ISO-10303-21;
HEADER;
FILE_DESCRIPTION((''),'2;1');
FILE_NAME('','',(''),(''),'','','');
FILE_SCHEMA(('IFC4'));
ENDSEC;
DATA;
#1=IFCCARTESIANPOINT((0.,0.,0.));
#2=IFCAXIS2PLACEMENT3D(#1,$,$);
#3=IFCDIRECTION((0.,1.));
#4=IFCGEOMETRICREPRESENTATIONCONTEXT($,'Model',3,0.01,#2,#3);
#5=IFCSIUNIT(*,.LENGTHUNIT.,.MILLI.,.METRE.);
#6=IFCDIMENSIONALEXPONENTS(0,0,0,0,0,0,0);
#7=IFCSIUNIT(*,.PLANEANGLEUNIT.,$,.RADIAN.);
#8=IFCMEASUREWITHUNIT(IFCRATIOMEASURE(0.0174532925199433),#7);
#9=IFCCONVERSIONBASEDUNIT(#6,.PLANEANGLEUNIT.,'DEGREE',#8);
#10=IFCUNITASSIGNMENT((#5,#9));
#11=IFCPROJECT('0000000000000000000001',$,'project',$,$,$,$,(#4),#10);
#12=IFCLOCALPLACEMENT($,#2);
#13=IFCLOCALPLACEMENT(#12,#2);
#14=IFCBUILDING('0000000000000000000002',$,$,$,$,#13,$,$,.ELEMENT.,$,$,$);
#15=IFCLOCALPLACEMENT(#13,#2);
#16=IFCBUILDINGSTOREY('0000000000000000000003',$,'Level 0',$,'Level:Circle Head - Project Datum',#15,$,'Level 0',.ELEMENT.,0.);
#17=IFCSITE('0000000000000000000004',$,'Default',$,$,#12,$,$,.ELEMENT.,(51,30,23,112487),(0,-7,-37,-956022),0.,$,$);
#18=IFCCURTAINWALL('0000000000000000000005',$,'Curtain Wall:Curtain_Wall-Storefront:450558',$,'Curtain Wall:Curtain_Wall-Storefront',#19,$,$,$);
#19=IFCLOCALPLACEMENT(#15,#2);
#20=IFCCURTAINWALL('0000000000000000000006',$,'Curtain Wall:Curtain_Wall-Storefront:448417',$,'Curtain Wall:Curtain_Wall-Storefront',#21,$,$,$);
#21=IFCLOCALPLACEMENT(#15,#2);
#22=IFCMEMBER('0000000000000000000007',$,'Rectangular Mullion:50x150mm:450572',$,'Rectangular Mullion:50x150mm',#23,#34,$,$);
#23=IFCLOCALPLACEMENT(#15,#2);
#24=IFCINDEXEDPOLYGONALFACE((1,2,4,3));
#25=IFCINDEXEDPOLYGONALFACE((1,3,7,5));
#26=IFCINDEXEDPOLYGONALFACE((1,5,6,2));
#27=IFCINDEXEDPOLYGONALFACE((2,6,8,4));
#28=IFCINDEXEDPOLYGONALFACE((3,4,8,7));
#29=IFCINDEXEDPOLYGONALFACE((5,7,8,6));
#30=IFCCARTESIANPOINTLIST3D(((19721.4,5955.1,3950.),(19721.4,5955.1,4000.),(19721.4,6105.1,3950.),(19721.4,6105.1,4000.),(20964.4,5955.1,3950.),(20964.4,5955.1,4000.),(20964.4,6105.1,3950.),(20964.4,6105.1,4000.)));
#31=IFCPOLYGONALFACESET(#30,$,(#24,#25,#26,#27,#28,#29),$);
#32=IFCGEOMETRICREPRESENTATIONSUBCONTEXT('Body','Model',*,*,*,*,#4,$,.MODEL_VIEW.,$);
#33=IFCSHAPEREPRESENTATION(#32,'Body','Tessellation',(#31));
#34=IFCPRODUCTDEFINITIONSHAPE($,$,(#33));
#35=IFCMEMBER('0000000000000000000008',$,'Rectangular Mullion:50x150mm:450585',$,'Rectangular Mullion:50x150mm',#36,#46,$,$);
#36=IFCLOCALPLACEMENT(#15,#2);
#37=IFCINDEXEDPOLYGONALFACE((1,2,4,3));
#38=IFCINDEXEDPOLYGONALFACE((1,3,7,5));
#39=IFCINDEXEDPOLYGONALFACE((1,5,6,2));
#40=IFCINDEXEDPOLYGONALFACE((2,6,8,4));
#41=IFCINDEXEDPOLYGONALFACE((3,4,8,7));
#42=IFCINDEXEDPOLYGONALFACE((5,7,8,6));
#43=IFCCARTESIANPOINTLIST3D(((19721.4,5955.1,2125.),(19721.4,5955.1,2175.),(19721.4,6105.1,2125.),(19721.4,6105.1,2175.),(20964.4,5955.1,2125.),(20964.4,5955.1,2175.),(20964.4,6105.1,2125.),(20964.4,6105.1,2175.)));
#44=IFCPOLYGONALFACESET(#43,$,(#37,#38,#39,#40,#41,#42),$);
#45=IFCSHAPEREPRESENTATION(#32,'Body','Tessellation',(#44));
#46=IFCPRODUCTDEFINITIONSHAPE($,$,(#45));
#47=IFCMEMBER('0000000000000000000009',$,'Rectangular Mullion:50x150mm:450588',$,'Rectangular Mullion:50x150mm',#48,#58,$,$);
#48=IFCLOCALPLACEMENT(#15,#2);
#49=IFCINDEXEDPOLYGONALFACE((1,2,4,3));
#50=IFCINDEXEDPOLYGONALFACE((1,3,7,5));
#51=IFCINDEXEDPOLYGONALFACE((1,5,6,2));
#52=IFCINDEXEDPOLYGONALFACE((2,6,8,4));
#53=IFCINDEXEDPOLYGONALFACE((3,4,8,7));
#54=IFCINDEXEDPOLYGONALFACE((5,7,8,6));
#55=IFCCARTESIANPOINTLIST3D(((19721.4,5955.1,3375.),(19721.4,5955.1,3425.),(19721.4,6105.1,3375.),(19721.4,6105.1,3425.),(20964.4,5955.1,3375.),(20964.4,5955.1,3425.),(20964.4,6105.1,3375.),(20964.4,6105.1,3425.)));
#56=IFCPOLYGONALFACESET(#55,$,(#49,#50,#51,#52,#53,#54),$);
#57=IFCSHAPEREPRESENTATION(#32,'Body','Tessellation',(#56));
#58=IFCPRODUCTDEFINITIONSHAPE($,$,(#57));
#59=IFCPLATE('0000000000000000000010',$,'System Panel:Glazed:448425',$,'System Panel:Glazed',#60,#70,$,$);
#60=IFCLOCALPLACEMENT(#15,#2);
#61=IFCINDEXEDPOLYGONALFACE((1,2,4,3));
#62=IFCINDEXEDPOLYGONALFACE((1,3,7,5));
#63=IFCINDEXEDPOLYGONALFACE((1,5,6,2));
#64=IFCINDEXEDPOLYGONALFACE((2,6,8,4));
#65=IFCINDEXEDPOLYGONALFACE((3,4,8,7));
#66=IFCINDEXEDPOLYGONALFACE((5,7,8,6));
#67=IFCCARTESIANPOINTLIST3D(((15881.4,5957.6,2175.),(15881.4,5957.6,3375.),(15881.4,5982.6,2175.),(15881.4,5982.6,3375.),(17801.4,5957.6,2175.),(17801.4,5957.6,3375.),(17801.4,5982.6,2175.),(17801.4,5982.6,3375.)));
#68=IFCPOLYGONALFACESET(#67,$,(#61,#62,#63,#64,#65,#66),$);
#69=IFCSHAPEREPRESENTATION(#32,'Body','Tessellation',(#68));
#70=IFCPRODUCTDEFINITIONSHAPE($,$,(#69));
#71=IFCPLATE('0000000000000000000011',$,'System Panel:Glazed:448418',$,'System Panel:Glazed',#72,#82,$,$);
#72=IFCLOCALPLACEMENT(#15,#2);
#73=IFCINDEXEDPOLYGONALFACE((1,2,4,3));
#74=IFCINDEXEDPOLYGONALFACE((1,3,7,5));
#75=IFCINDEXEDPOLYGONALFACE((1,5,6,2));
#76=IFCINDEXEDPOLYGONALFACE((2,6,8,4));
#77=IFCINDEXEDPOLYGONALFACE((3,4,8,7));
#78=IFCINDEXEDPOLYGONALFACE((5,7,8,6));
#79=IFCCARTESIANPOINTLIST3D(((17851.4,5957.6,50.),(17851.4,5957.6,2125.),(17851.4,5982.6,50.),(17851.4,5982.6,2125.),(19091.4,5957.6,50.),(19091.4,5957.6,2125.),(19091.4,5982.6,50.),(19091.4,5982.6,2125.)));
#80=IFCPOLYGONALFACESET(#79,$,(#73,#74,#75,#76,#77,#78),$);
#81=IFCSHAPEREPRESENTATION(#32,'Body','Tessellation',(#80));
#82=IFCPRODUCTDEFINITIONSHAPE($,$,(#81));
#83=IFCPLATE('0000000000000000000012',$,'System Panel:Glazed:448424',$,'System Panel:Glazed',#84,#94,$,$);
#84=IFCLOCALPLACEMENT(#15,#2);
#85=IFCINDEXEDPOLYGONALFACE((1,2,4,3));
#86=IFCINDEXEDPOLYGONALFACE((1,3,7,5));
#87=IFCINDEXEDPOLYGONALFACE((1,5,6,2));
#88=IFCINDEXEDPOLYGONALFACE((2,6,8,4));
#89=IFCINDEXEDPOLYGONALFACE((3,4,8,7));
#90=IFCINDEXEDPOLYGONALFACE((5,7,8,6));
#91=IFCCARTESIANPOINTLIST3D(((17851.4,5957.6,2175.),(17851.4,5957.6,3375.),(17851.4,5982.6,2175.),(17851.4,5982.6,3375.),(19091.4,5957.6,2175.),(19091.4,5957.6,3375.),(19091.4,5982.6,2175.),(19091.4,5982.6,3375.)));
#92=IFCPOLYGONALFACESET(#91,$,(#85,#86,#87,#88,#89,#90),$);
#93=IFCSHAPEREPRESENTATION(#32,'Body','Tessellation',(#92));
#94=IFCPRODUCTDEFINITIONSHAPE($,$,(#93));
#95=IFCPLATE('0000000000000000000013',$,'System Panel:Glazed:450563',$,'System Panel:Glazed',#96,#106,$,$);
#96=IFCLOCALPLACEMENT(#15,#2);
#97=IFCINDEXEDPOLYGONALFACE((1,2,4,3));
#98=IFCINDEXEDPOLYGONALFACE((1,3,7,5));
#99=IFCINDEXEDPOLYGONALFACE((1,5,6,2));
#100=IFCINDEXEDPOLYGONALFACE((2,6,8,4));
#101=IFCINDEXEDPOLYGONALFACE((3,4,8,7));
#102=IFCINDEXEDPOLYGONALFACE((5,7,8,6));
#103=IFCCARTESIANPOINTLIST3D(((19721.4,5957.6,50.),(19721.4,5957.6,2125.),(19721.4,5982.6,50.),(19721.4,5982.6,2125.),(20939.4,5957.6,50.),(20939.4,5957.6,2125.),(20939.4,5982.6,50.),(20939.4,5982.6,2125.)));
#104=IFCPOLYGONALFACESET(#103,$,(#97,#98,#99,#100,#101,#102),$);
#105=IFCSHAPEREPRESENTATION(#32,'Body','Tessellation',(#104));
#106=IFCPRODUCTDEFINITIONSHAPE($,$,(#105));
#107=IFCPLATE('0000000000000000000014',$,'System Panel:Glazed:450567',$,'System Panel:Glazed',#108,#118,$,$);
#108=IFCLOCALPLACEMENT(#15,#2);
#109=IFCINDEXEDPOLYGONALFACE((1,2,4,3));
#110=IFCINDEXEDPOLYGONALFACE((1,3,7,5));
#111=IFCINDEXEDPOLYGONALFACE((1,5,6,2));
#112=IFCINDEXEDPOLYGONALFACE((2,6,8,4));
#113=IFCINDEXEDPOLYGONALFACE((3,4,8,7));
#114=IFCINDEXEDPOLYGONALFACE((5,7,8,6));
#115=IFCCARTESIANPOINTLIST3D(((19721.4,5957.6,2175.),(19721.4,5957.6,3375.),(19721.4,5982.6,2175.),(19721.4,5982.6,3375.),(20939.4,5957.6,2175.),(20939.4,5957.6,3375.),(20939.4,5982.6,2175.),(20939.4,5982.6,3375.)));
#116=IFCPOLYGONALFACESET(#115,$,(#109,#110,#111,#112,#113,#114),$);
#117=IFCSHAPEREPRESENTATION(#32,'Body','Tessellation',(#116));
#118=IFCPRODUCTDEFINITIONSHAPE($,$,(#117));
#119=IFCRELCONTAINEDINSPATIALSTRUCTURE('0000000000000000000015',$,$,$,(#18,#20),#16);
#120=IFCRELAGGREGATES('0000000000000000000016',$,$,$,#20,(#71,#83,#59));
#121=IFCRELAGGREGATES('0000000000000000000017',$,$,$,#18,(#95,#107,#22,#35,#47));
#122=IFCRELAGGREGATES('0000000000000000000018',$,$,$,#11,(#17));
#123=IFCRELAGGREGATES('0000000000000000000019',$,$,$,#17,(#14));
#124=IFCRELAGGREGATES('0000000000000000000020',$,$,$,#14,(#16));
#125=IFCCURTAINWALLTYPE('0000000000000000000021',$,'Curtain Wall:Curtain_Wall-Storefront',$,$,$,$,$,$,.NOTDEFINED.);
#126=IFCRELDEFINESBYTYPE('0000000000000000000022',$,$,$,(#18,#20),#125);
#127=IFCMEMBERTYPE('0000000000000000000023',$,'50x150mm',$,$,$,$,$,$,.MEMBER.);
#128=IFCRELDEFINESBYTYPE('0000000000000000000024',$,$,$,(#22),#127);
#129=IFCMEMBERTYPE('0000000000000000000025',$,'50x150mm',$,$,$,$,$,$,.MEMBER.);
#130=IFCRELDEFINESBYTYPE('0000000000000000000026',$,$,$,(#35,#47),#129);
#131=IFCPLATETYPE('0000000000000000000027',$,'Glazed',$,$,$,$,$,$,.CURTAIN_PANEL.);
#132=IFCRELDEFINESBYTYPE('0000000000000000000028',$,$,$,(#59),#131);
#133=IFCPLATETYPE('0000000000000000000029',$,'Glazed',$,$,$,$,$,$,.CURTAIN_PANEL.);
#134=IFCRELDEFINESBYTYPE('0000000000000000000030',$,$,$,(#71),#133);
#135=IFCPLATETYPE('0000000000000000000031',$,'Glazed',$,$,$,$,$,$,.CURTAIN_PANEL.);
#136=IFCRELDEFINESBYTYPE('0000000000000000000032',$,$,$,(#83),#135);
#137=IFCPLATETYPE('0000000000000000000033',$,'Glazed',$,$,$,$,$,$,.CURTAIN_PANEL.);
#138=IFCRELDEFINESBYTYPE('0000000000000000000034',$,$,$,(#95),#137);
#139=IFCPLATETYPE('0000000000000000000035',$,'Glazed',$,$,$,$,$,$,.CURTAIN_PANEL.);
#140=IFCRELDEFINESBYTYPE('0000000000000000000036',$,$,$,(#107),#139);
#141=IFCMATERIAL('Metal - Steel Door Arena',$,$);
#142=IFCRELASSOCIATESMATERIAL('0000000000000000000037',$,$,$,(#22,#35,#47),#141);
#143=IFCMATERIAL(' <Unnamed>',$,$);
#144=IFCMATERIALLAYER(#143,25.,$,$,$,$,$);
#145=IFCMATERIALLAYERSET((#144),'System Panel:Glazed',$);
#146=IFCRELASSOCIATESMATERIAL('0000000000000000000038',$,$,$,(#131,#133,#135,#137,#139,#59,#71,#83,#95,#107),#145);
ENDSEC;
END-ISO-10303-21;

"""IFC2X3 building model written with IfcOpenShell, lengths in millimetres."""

from ifc_helpers import new_model, entity, si_unit, converted_unit, direction, frame, origin, origin_2d_with_axis, place, context, subcontext, project, spatial, rectangle, extrude, source, transform, mapped, material, layer, layer_set, layer_usage, type_object, type_shapes, element, aggregate, save


model = new_model("IFC2X3")

# Units and contexts
model_context = context("Model", 3, precision=0.01, world=origin(), true_north=direction((0.0, 1.0)))
body_context = subcontext(model_context, "Body", "Model", "MODEL_VIEW")
ifc_project = project(units=[si_unit("LENGTHUNIT", "METRE", prefix="MILLI"), converted_unit("PLANEANGLEUNIT", "DEGREE", entity("IfcRatioMeasure", 0.0174532925199433), si_unit("PLANEANGLEUNIT", "RADIAN"), dimensions=[0, 0, 0, 0, 0, 0, 0])], contexts=[model_context])

# Site, building, storey
site_placement = place(None, origin())
site = spatial("IfcSite", under=ifc_project, at=site_placement, Name="Default", CompositionType="ELEMENT", RefLatitude=(51, 30, 23, 112487), RefLongitude=(0, -7, -37, -956022), RefElevation=0.0)
building_placement = place(site_placement, origin())
building = spatial("IfcBuilding", under=site, at=building_placement, CompositionType="ELEMENT")
storey_placement = place(building_placement, origin())
storey = spatial("IfcBuildingStorey", under=building, at=storey_placement, Name="Level 0", ObjectType="Level:Circle Head - Project Datum", LongName="Level 0", CompositionType="ELEMENT", Elevation=0.0)

# Curtain walls
curtain_wall_type = type_object("IfcCurtainWallType", Name="Curtain Wall:Curtain_Wall-Storefront", PredefinedType="NOTDEFINED")
curtain_wall_1_placement = place(storey_placement, origin())
curtain_wall_1 = element("IfcCurtainWall", 1, at=curtain_wall_1_placement, inside=storey, type_object=curtain_wall_type, Name="Curtain Wall:Curtain_Wall-Storefront:450558", ObjectType="Curtain Wall:Curtain_Wall-Storefront")
ifc_material_1 = material(Name="Metal - Steel Door Arena")
curtain_wall_2_placement = place(storey_placement, origin())
curtain_wall_2 = element("IfcCurtainWall", 2, at=curtain_wall_2_placement, inside=storey, type_object=curtain_wall_type, Name="Curtain Wall:Curtain_Wall-Storefront:448417", ObjectType="Curtain Wall:Curtain_Wall-Storefront")

# Members
member_type_1 = type_object("IfcMemberType", Name="50x150mm", PredefinedType="MEMBER")
shared_shape_1 = source(origin(), body_context, "Body", "SweptSolid", [
    extrude(rectangle(XDim=150.0, YDim=50.0, at=origin_2d_with_axis()), frame((-25.0, 0.0, -1243.0), z_axis=(0.0, 0.0, 1.0), x_axis=(0.0, -1.0, 0.0)), (0.0, 0.0, 1.0), 1243.0),
])
type_shapes(member_type_1, [shared_shape_1])
member_1_placement = place(storey_placement, frame((19721.4, 6030.1, 4000.0), z_axis=(-1.0, 0.0, 0.0), x_axis=(0.0, 0.0, 1.0)))
member_1 = element("IfcMember", 3, at=member_1_placement, type_object=member_type_1, material=ifc_material_1, Name="Rectangular Mullion:50x150mm:450572", ObjectType="Rectangular Mullion:50x150mm", context=body_context, shape_type="MappedRepresentation", body=[
    mapped(shared_shape_1, transform((0.0, 0.0, 0.0), scale=1.0)),
])
member_type_2 = type_object("IfcMemberType", Name="50x150mm", PredefinedType="MEMBER")
shared_shape_2 = source(origin(), body_context, "Body", "SweptSolid", [
    extrude(rectangle(XDim=150.0, YDim=50.0, at=origin_2d_with_axis()), frame((0.0, 0.0, -1243.0), z_axis=(0.0, 0.0, 1.0), x_axis=(0.0, -1.0, 0.0)), (0.0, 0.0, 1.0), 1243.0),
])
type_shapes(member_type_2, [shared_shape_2])
member_2_placement = place(storey_placement, frame((19721.4, 6030.1, 2150.0), z_axis=(-1.0, 0.0, 0.0), x_axis=(0.0, 0.0, 1.0)))
member_2 = element("IfcMember", 4, at=member_2_placement, type_object=member_type_2, material=ifc_material_1, Name="Rectangular Mullion:50x150mm:450585", ObjectType="Rectangular Mullion:50x150mm", context=body_context, shape_type="MappedRepresentation", body=[
    mapped(shared_shape_2, transform((0.0, 0.0, 0.0), scale=1.0)),
])
member_3_placement = place(storey_placement, frame((19721.4, 6030.1, 3400.0), z_axis=(-1.0, 0.0, 0.0), x_axis=(0.0, 0.0, 1.0)))
member_3 = element("IfcMember", 5, at=member_3_placement, type_object=member_type_2, material=ifc_material_1, Name="Rectangular Mullion:50x150mm:450588", ObjectType="Rectangular Mullion:50x150mm", context=body_context, shape_type="MappedRepresentation", body=[
    mapped(shared_shape_2, transform((0.0, 0.0, 0.0), scale=1.0)),
])

# Plates
ifc_material_2 = material(Name=" <Unnamed>")
ifc_layer_1 = layer(ifc_material_2, 25.0)
ifc_layer_set_1 = layer_set([ifc_layer_1], Name="System Panel:Glazed")
ifc_layer_usage_1 = layer_usage(ifc_layer_set_1, "AXIS3", "POSITIVE", 0.2)
plate_type_1 = type_object("IfcPlateType", Name="Glazed", PredefinedType="CURTAIN_PANEL", material=ifc_layer_set_1)
shared_shape_3 = source(origin(), body_context, "Body", "SweptSolid", [
    extrude(rectangle(XDim=25.0, YDim=1920.0, at=origin_2d_with_axis()), frame((0.0, 60.0, 0.0), z_axis=(0.0, 0.0, 1.0), x_axis=(0.0, 1.0, 0.0)), (0.0, 0.0, 1.0), 1200.0),
])
type_shapes(plate_type_1, [shared_shape_3])
plate_1_placement = place(curtain_wall_2_placement, frame((16841.4, 6030.1, 2175.0), z_axis=(0.0, 0.0, 1.0), x_axis=(-1.0, 0.0, 0.0)))
plate_1 = element("IfcPlate", 6, at=plate_1_placement, type_object=plate_type_1, material=ifc_layer_usage_1, Name="System Panel:Glazed:448425", ObjectType="System Panel:Glazed", context=body_context, shape_type="MappedRepresentation", body=[
    mapped(shared_shape_3, transform((0.0, 0.0, 0.0), scale=1.0)),
])
ifc_layer_usage_2 = layer_usage(ifc_layer_set_1, "AXIS3", "POSITIVE", 0.2)
plate_type_2 = type_object("IfcPlateType", Name="Glazed", PredefinedType="CURTAIN_PANEL", material=ifc_layer_set_1)
shared_shape_4 = source(origin(), body_context, "Body", "SweptSolid", [
    extrude(rectangle(XDim=25.0, YDim=1240.0, at=origin_2d_with_axis()), frame((0.0, 60.0, 0.0), z_axis=(0.0, 0.0, 1.0), x_axis=(0.0, 1.0, 0.0)), (0.0, 0.0, 1.0), 2075.0),
])
type_shapes(plate_type_2, [shared_shape_4])
plate_2_placement = place(curtain_wall_2_placement, frame((18471.4, 6030.1, 50.0), z_axis=(0.0, 0.0, 1.0), x_axis=(-1.0, 0.0, 0.0)))
plate_2 = element("IfcPlate", 7, at=plate_2_placement, type_object=plate_type_2, material=ifc_layer_usage_2, Name="System Panel:Glazed:448418", ObjectType="System Panel:Glazed", context=body_context, shape_type="MappedRepresentation", body=[
    mapped(shared_shape_4, transform((0.0, 0.0, 0.0), scale=1.0)),
])
ifc_layer_usage_3 = layer_usage(ifc_layer_set_1, "AXIS3", "POSITIVE", 0.2)
plate_type_3 = type_object("IfcPlateType", Name="Glazed", PredefinedType="CURTAIN_PANEL", material=ifc_layer_set_1)
shared_shape_5 = source(origin(), body_context, "Body", "SweptSolid", [
    extrude(rectangle(XDim=25.0, YDim=1240.0, at=origin_2d_with_axis()), frame((0.0, 60.0, 0.0), z_axis=(0.0, 0.0, 1.0), x_axis=(0.0, 1.0, 0.0)), (0.0, 0.0, 1.0), 1200.0),
])
type_shapes(plate_type_3, [shared_shape_5])
plate_3_placement = place(curtain_wall_2_placement, frame((18471.4, 6030.1, 2175.0), z_axis=(0.0, 0.0, 1.0), x_axis=(-1.0, 0.0, 0.0)))
plate_3 = element("IfcPlate", 8, at=plate_3_placement, type_object=plate_type_3, material=ifc_layer_usage_3, Name="System Panel:Glazed:448424", ObjectType="System Panel:Glazed", context=body_context, shape_type="MappedRepresentation", body=[
    mapped(shared_shape_5, transform((0.0, 0.0, 0.0), scale=1.0)),
])
aggregate(curtain_wall_2, [plate_2, plate_3, plate_1])
ifc_layer_usage_4 = layer_usage(ifc_layer_set_1, "AXIS3", "POSITIVE", 0.2)
plate_type_4 = type_object("IfcPlateType", Name="Glazed", PredefinedType="CURTAIN_PANEL", material=ifc_layer_set_1)
shared_shape_6 = source(origin(), body_context, "Body", "SweptSolid", [
    extrude(rectangle(XDim=25.0, YDim=1218.0, at=origin_2d_with_axis()), frame((0.0, 60.0, 0.0), z_axis=(0.0, 0.0, 1.0), x_axis=(0.0, 1.0, 0.0)), (0.0, 0.0, 1.0), 2075.0),
])
type_shapes(plate_type_4, [shared_shape_6])
plate_4_placement = place(curtain_wall_1_placement, frame((20330.4, 6030.1, 50.0), z_axis=(0.0, 0.0, 1.0), x_axis=(-1.0, 0.0, 0.0)))
plate_4 = element("IfcPlate", 9, at=plate_4_placement, type_object=plate_type_4, material=ifc_layer_usage_4, Name="System Panel:Glazed:450563", ObjectType="System Panel:Glazed", context=body_context, shape_type="MappedRepresentation", body=[
    mapped(shared_shape_6, transform((0.0, 0.0, 0.0), scale=1.0)),
])
ifc_layer_usage_5 = layer_usage(ifc_layer_set_1, "AXIS3", "POSITIVE", 0.2)
plate_type_5 = type_object("IfcPlateType", Name="Glazed", PredefinedType="CURTAIN_PANEL", material=ifc_layer_set_1)
shared_shape_7 = source(origin(), body_context, "Body", "SweptSolid", [
    extrude(rectangle(XDim=25.0, YDim=1218.0, at=origin_2d_with_axis()), frame((0.0, 60.0, 0.0), z_axis=(0.0, 0.0, 1.0), x_axis=(0.0, 1.0, 0.0)), (0.0, 0.0, 1.0), 1200.0),
])
type_shapes(plate_type_5, [shared_shape_7])
plate_5_placement = place(curtain_wall_1_placement, frame((20330.4, 6030.1, 2175.0), z_axis=(0.0, 0.0, 1.0), x_axis=(-1.0, 0.0, 0.0)))
plate_5 = element("IfcPlate", 10, at=plate_5_placement, type_object=plate_type_5, material=ifc_layer_usage_5, Name="System Panel:Glazed:450567", ObjectType="System Panel:Glazed", context=body_context, shape_type="MappedRepresentation", body=[
    mapped(shared_shape_7, transform((0.0, 0.0, 0.0), scale=1.0)),
])
aggregate(curtain_wall_1, [plate_4, plate_5, member_1, member_2, member_3])

save(model, "model.ifc")
